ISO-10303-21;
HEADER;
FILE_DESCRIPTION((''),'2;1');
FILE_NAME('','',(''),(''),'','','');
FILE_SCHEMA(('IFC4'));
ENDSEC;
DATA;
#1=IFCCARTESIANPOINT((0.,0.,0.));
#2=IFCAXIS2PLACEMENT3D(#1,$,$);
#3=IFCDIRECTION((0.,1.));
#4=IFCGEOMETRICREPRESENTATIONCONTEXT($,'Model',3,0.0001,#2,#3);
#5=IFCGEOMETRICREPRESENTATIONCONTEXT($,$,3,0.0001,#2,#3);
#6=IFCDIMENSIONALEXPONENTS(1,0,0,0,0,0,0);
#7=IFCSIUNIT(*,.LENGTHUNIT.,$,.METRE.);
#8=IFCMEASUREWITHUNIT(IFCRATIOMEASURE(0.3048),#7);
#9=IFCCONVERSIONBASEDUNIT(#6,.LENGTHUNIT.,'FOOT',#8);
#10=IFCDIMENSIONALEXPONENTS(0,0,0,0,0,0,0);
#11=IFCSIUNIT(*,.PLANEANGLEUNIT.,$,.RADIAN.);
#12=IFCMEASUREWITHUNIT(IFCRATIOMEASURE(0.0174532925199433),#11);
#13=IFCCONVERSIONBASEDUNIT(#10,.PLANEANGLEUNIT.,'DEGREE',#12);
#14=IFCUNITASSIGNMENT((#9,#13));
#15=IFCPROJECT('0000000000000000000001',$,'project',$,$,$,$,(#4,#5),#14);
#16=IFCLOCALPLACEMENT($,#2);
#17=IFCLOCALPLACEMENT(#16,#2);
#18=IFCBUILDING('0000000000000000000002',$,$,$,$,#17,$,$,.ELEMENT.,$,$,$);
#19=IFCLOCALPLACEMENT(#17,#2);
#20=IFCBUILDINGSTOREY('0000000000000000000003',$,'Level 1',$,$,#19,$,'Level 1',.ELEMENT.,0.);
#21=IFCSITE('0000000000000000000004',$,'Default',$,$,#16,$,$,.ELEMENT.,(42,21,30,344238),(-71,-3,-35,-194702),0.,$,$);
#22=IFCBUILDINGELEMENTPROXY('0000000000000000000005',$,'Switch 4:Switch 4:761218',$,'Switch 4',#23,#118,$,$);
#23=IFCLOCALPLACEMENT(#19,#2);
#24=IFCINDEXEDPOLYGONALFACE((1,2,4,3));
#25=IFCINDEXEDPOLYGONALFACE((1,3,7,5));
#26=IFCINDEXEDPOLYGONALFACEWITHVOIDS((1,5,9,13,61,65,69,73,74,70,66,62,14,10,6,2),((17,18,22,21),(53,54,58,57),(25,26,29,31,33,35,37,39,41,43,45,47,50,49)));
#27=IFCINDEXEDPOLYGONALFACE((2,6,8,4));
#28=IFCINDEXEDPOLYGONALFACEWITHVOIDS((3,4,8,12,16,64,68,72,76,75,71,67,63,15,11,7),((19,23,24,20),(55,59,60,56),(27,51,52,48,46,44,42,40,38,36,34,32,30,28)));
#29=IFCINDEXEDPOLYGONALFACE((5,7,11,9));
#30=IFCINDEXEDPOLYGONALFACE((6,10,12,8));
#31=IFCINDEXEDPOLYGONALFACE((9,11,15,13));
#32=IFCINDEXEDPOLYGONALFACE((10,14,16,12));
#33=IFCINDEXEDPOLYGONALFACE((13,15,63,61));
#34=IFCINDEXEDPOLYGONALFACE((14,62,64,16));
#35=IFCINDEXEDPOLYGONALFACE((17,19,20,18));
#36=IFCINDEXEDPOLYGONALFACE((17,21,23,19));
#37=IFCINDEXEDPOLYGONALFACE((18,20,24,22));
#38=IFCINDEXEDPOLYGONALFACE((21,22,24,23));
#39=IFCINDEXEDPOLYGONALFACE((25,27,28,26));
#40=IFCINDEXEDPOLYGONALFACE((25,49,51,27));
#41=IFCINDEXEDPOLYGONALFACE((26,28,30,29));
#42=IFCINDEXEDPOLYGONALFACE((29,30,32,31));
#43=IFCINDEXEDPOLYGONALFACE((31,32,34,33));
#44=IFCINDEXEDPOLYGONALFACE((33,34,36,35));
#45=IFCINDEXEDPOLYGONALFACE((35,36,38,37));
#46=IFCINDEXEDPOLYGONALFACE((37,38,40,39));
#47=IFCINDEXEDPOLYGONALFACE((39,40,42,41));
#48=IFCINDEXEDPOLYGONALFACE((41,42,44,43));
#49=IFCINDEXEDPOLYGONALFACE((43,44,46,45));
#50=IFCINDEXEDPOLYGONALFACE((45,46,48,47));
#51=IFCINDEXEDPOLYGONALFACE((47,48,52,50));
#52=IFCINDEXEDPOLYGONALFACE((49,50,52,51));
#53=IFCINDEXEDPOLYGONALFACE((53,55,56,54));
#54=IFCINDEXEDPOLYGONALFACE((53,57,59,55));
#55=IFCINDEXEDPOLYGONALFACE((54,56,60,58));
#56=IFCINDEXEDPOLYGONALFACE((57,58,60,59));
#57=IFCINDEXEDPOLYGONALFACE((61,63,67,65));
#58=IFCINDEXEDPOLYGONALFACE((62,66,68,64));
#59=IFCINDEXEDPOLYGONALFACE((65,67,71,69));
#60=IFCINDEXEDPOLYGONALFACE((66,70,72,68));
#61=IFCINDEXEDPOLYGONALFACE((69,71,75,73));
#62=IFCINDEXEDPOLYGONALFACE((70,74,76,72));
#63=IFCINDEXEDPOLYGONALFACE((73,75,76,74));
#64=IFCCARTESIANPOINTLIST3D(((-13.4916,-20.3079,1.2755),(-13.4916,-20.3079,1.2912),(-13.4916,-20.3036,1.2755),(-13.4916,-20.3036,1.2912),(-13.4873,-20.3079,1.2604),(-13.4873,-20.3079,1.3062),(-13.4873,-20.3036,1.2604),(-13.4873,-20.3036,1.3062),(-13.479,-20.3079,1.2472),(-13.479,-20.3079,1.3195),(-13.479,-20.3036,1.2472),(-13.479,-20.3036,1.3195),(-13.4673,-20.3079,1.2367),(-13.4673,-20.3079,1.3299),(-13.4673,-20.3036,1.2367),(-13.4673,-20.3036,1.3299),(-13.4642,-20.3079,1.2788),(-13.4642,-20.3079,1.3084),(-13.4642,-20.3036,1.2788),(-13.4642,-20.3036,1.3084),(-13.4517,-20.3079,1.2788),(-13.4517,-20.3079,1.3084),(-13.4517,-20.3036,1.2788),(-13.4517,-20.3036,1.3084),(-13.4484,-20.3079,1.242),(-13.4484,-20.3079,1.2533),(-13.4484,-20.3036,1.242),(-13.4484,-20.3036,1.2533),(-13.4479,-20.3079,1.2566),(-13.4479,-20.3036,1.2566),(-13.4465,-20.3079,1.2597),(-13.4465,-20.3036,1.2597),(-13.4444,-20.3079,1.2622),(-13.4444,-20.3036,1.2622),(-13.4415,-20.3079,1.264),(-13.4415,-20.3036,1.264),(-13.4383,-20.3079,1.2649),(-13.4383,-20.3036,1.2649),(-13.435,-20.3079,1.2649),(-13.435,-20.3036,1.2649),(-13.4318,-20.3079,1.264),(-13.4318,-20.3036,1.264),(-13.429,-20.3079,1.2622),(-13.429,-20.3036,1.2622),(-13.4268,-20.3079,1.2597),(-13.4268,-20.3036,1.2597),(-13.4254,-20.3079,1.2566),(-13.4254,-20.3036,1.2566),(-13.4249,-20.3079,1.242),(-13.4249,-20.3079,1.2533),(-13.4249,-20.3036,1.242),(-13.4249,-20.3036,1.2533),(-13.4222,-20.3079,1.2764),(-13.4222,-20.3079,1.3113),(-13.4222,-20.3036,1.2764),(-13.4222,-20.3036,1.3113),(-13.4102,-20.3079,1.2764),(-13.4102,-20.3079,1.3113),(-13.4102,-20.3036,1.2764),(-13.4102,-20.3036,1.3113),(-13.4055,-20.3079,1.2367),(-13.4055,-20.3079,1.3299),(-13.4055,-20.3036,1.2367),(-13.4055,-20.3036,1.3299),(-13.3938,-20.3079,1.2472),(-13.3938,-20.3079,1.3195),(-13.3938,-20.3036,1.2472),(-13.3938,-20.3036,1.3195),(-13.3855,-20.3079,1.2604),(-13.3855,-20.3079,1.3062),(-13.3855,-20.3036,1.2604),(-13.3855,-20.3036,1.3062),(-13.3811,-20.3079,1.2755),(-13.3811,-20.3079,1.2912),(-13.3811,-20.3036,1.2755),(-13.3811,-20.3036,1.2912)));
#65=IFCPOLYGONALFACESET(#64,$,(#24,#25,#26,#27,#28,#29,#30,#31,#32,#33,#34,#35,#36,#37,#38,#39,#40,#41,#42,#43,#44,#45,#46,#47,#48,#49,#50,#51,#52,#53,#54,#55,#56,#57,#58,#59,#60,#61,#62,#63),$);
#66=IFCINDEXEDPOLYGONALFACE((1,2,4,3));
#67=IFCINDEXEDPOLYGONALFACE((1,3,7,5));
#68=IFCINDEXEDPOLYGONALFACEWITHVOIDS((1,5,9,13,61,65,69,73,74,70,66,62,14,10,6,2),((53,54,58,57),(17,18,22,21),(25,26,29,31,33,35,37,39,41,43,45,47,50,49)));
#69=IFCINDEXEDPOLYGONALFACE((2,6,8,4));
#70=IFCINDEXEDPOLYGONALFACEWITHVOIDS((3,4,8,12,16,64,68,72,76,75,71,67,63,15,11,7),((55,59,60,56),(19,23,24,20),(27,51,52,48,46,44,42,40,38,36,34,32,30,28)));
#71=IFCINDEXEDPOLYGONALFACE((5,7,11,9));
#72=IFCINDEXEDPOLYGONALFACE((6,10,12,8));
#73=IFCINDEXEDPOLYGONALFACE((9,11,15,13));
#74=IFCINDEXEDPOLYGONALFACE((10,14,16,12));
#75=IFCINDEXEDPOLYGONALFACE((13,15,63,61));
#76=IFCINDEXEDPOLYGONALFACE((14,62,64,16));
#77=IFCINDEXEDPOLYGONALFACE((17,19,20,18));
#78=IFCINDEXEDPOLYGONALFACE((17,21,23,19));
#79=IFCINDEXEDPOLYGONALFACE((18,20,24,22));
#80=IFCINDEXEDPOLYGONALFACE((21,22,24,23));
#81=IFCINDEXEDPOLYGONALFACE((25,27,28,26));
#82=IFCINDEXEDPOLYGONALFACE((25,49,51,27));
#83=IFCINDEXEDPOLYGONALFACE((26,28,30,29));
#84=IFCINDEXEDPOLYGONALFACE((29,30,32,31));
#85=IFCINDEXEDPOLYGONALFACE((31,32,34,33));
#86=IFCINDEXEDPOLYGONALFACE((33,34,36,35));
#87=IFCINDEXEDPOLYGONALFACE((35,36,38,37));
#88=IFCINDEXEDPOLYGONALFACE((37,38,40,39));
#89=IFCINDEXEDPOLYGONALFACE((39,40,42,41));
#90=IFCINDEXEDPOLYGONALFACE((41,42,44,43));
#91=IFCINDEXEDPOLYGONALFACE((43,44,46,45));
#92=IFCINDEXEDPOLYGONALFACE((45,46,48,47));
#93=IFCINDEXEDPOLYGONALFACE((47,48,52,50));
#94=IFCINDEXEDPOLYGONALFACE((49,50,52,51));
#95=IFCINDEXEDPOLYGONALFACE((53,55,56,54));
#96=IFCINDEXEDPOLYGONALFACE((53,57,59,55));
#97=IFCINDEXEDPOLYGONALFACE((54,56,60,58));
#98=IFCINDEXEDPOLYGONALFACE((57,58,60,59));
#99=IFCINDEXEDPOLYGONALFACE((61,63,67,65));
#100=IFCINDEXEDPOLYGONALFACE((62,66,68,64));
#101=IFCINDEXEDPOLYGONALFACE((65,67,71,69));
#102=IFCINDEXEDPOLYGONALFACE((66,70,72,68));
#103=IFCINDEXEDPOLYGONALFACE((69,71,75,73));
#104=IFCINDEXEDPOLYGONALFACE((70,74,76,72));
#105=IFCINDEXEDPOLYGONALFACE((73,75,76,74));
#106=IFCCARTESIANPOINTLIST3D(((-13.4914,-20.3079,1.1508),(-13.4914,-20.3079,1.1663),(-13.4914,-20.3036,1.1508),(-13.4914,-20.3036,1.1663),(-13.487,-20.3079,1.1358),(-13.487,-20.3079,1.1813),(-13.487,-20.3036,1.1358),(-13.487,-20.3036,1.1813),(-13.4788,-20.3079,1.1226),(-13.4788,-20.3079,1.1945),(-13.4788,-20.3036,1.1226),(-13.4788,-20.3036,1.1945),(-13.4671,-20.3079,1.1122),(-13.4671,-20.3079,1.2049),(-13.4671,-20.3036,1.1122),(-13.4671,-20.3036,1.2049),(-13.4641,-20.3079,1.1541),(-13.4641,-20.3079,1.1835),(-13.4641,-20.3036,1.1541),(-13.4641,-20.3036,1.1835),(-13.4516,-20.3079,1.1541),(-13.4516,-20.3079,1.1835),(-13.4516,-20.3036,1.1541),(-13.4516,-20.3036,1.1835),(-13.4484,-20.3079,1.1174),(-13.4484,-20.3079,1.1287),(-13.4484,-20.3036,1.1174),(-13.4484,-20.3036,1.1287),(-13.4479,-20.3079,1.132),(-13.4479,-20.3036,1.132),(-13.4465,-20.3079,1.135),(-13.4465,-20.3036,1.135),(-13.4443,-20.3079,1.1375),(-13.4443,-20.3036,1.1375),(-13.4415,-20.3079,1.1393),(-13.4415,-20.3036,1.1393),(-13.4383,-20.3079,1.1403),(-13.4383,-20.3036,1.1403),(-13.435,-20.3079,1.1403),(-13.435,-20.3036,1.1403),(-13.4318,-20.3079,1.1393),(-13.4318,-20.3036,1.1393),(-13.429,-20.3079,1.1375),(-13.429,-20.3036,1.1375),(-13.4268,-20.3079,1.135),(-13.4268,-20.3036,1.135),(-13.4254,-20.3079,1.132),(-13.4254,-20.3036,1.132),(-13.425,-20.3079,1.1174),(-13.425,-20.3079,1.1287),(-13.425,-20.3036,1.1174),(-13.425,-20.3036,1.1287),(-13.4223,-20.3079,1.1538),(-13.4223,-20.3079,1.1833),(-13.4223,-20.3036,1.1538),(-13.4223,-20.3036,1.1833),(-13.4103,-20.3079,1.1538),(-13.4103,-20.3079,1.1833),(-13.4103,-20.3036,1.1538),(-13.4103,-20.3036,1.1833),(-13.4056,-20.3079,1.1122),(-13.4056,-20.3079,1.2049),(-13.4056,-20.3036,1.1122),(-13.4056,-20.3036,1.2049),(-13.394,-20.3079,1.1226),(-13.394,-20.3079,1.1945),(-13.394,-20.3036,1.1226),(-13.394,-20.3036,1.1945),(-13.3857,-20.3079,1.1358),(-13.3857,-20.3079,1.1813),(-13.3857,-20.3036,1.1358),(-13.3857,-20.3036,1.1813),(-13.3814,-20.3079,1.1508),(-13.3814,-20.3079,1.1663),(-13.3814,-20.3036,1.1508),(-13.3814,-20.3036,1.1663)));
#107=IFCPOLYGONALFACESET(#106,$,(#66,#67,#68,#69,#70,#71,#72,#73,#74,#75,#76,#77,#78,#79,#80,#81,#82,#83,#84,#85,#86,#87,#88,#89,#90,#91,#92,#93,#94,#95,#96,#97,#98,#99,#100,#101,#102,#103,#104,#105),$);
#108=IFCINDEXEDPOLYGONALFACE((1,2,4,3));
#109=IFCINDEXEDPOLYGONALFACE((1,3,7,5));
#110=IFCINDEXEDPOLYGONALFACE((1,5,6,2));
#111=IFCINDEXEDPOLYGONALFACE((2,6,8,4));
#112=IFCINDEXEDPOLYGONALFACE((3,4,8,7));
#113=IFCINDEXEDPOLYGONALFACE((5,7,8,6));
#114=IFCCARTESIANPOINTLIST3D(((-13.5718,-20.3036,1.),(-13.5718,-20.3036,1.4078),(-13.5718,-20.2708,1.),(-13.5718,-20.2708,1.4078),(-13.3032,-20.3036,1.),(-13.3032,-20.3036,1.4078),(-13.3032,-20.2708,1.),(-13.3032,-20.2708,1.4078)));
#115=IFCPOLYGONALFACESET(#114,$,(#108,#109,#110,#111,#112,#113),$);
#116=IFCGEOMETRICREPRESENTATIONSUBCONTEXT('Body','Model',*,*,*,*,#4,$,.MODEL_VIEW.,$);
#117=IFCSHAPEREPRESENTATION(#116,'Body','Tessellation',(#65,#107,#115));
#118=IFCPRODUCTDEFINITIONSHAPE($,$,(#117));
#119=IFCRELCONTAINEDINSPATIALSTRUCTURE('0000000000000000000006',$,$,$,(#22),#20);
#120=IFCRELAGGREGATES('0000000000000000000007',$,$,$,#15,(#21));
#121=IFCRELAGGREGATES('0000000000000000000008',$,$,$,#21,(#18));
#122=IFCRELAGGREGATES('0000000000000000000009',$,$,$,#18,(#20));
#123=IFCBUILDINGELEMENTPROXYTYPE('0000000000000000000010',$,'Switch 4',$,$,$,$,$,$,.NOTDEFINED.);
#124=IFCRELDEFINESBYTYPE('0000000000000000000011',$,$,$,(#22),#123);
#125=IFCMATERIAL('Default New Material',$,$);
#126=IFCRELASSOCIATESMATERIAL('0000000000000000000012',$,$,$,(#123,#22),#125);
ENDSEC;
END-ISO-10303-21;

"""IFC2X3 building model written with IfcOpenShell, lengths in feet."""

from ifc_helpers import new_model, entity, si_unit, converted_unit, direction, frame, frame_2d, origin, origin_2d_with_axis, place, context, subcontext, project, spatial, polyline, circle_curve, parameter, trimmed, segment, composite_curve, rectangle, outline, extrude, source, transform, mapped, material, type_object, type_shapes, element, save


model = new_model("IFC2X3")

# Units and contexts
model_context = context("Model", 3, precision=0.0001, world=origin(), true_north=direction((0.0, 1.0)))
context_of_model = context(None, 3, precision=0.0001, world=origin(), true_north=direction((0.0, 1.0)))
body_context = subcontext(model_context, "Body", "Model", "MODEL_VIEW")
ifc_project = project(units=[converted_unit("LENGTHUNIT", "FOOT", entity("IfcRatioMeasure", 0.3048), si_unit("LENGTHUNIT", "METRE"), dimensions=[1, 0, 0, 0, 0, 0, 0]), converted_unit("PLANEANGLEUNIT", "DEGREE", entity("IfcRatioMeasure", 0.0174532925199433), si_unit("PLANEANGLEUNIT", "RADIAN"), dimensions=[0, 0, 0, 0, 0, 0, 0])], contexts=[model_context, context_of_model])

# Site, building, storey
site_placement = place(None, origin())
site = spatial("IfcSite", under=ifc_project, at=site_placement, Name="Default", CompositionType="ELEMENT", RefLatitude=(42, 21, 30, 344238), RefLongitude=(-71, -3, -35, -194702), RefElevation=0.0)
building_placement = place(site_placement, origin())
building = spatial("IfcBuilding", under=site, at=building_placement, CompositionType="ELEMENT")
storey_placement = place(building_placement, origin())
storey = spatial("IfcBuildingStorey", under=building, at=storey_placement, Name="Level 1", LongName="Level 1", CompositionType="ELEMENT", Elevation=0.0)

# Shared definitions
ifc_material_1 = material(Name="Default New Material")

# Building element proxy
building_element_proxy_type_1 = type_object("IfcBuildingElementProxyType", Name="Switch 4", PredefinedType="NOTDEFINED", material=ifc_material_1)
shared_shape_1 = source(origin(), body_context, "Body", "SweptSolid", [
    extrude(outline(composite_curve([segment(polyline([(-0.0309, -0.0466), (0.0309, -0.0466)]), True, "CONTINUOUS"), segment(trimmed(circle_curve(frame_2d((-0.0003, 0.0), x_axis=(-1.0, 0.0)), 0.0561), [parameter(123.794741)], [parameter(236.205259)], True, "PARAMETER"), True, "CONTINUOUS"), segment(polyline([(0.0309, 0.0466), (-0.0309, 0.0466)]), True, "CONTINUOUS"), segment(trimmed(circle_curve(frame_2d((0.0003, 0.0), x_axis=(1.0, 0.0)), 0.0561), [parameter(123.794741)], [parameter(236.205259)], True, "PARAMETER"), True, "CONTINUOUS")], self_intersect=False), holes=[polyline([(0.0142, 0.0279), (0.0262, 0.0279), (0.0262, -0.0069), (0.0142, -0.0069), (0.0142, 0.0279)]), polyline([(-0.0153, 0.025), (-0.0153, -0.0045), (-0.0278, -0.0045), (-0.0278, 0.025), (-0.0153, 0.025)]), composite_curve([segment(polyline([(-0.012, -0.0413), (-0.012, -0.03)]), True, "CONTINUOUS"), segment(trimmed(circle_curve(frame_2d((-0.0003, -0.03), x_axis=(-1.0, 0.0)), 0.0117), [parameter(180.0)], [parameter(0.0)], True, "PARAMETER"), False, "CONTINUOUS"), segment(polyline([(0.0115, -0.03), (0.0115, -0.0413)]), True, "CONTINUOUS"), segment(polyline([(0.0115, -0.0413), (-0.012, -0.0413)]), True, "CONTINUOUS")], self_intersect=False)]), frame((-0.0011, 0.0328, 0.2833), z_axis=(0.0, 1.0, 0.0), x_axis=(-1.0, 0.0, 0.0)), (0.0, 0.0, 1.0), 0.0042),
    extrude(outline(composite_curve([segment(polyline([(-0.0308, -0.0464), (0.0308, -0.0464)]), True, "CONTINUOUS"), segment(trimmed(circle_curve(frame_2d((-0.0003, 0.0), x_axis=(-1.0, 0.0)), 0.0558), [parameter(123.794741)], [parameter(236.205259)], True, "PARAMETER"), True, "CONTINUOUS"), segment(polyline([(0.0308, 0.0464), (-0.0308, 0.0464)]), True, "CONTINUOUS"), segment(trimmed(circle_curve(frame_2d((0.0003, 0.0), x_axis=(1.0, 0.0)), 0.0558), [parameter(123.794741)], [parameter(236.205259)], True, "PARAMETER"), True, "CONTINUOUS")], self_intersect=False), holes=[polyline([(0.0141, 0.0247), (0.026, 0.0247), (0.026, -0.0047), (0.0141, -0.0047), (0.0141, 0.0247)]), polyline([(-0.0152, 0.0249), (-0.0152, -0.0045), (-0.0277, -0.0045), (-0.0277, 0.0249), (-0.0152, 0.0249)]), composite_curve([segment(polyline([(-0.012, -0.0411), (-0.012, -0.0299)]), True, "CONTINUOUS"), segment(trimmed(circle_curve(frame_2d((-0.0003, -0.0299), x_axis=(-1.0, 0.0)), 0.0117), [parameter(180.0)], [parameter(0.0)], True, "PARAMETER"), False, "CONTINUOUS"), segment(polyline([(0.0114, -0.0299), (0.0114, -0.0411)]), True, "CONTINUOUS"), segment(polyline([(0.0114, -0.0411), (-0.012, -0.0411)]), True, "CONTINUOUS")], self_intersect=False)]), frame((-0.0011, 0.0328, 0.1586), z_axis=(0.0, 1.0, 0.0), x_axis=(-1.0, 0.0, 0.0)), (0.0, 0.0, 1.0), 0.0042),
    extrude(rectangle(XDim=0.0328, YDim=0.2687, at=origin_2d_with_axis()), frame((0.0, 0.0164, 0.0), z_axis=(0.0, 0.0, 1.0), x_axis=(0.0, -1.0, 0.0)), (0.0, 0.0, 1.0), 0.4078),
])
type_shapes(building_element_proxy_type_1, [shared_shape_1])
for number, where, z_axis, x_axis, name in (
    (1, (-13.4375, -20.2708, 1.0), (0.0, 0.0, 1.0), (-1.0, 0.0, 0.0), "Switch 4:Switch 4:761218"),
):
    element("IfcBuildingElementProxy", number, at=place(storey_placement, frame(where, z_axis=z_axis, x_axis=x_axis)), inside=storey, type_object=building_element_proxy_type_1, material=ifc_material_1, Name=name, ObjectType="Switch 4", context=body_context, shape_type="MappedRepresentation", body=[
        mapped(shared_shape_1, transform((0.0, 0.0, 0.0), scale=1.0)),
    ])

save(model, "model.ifc")
